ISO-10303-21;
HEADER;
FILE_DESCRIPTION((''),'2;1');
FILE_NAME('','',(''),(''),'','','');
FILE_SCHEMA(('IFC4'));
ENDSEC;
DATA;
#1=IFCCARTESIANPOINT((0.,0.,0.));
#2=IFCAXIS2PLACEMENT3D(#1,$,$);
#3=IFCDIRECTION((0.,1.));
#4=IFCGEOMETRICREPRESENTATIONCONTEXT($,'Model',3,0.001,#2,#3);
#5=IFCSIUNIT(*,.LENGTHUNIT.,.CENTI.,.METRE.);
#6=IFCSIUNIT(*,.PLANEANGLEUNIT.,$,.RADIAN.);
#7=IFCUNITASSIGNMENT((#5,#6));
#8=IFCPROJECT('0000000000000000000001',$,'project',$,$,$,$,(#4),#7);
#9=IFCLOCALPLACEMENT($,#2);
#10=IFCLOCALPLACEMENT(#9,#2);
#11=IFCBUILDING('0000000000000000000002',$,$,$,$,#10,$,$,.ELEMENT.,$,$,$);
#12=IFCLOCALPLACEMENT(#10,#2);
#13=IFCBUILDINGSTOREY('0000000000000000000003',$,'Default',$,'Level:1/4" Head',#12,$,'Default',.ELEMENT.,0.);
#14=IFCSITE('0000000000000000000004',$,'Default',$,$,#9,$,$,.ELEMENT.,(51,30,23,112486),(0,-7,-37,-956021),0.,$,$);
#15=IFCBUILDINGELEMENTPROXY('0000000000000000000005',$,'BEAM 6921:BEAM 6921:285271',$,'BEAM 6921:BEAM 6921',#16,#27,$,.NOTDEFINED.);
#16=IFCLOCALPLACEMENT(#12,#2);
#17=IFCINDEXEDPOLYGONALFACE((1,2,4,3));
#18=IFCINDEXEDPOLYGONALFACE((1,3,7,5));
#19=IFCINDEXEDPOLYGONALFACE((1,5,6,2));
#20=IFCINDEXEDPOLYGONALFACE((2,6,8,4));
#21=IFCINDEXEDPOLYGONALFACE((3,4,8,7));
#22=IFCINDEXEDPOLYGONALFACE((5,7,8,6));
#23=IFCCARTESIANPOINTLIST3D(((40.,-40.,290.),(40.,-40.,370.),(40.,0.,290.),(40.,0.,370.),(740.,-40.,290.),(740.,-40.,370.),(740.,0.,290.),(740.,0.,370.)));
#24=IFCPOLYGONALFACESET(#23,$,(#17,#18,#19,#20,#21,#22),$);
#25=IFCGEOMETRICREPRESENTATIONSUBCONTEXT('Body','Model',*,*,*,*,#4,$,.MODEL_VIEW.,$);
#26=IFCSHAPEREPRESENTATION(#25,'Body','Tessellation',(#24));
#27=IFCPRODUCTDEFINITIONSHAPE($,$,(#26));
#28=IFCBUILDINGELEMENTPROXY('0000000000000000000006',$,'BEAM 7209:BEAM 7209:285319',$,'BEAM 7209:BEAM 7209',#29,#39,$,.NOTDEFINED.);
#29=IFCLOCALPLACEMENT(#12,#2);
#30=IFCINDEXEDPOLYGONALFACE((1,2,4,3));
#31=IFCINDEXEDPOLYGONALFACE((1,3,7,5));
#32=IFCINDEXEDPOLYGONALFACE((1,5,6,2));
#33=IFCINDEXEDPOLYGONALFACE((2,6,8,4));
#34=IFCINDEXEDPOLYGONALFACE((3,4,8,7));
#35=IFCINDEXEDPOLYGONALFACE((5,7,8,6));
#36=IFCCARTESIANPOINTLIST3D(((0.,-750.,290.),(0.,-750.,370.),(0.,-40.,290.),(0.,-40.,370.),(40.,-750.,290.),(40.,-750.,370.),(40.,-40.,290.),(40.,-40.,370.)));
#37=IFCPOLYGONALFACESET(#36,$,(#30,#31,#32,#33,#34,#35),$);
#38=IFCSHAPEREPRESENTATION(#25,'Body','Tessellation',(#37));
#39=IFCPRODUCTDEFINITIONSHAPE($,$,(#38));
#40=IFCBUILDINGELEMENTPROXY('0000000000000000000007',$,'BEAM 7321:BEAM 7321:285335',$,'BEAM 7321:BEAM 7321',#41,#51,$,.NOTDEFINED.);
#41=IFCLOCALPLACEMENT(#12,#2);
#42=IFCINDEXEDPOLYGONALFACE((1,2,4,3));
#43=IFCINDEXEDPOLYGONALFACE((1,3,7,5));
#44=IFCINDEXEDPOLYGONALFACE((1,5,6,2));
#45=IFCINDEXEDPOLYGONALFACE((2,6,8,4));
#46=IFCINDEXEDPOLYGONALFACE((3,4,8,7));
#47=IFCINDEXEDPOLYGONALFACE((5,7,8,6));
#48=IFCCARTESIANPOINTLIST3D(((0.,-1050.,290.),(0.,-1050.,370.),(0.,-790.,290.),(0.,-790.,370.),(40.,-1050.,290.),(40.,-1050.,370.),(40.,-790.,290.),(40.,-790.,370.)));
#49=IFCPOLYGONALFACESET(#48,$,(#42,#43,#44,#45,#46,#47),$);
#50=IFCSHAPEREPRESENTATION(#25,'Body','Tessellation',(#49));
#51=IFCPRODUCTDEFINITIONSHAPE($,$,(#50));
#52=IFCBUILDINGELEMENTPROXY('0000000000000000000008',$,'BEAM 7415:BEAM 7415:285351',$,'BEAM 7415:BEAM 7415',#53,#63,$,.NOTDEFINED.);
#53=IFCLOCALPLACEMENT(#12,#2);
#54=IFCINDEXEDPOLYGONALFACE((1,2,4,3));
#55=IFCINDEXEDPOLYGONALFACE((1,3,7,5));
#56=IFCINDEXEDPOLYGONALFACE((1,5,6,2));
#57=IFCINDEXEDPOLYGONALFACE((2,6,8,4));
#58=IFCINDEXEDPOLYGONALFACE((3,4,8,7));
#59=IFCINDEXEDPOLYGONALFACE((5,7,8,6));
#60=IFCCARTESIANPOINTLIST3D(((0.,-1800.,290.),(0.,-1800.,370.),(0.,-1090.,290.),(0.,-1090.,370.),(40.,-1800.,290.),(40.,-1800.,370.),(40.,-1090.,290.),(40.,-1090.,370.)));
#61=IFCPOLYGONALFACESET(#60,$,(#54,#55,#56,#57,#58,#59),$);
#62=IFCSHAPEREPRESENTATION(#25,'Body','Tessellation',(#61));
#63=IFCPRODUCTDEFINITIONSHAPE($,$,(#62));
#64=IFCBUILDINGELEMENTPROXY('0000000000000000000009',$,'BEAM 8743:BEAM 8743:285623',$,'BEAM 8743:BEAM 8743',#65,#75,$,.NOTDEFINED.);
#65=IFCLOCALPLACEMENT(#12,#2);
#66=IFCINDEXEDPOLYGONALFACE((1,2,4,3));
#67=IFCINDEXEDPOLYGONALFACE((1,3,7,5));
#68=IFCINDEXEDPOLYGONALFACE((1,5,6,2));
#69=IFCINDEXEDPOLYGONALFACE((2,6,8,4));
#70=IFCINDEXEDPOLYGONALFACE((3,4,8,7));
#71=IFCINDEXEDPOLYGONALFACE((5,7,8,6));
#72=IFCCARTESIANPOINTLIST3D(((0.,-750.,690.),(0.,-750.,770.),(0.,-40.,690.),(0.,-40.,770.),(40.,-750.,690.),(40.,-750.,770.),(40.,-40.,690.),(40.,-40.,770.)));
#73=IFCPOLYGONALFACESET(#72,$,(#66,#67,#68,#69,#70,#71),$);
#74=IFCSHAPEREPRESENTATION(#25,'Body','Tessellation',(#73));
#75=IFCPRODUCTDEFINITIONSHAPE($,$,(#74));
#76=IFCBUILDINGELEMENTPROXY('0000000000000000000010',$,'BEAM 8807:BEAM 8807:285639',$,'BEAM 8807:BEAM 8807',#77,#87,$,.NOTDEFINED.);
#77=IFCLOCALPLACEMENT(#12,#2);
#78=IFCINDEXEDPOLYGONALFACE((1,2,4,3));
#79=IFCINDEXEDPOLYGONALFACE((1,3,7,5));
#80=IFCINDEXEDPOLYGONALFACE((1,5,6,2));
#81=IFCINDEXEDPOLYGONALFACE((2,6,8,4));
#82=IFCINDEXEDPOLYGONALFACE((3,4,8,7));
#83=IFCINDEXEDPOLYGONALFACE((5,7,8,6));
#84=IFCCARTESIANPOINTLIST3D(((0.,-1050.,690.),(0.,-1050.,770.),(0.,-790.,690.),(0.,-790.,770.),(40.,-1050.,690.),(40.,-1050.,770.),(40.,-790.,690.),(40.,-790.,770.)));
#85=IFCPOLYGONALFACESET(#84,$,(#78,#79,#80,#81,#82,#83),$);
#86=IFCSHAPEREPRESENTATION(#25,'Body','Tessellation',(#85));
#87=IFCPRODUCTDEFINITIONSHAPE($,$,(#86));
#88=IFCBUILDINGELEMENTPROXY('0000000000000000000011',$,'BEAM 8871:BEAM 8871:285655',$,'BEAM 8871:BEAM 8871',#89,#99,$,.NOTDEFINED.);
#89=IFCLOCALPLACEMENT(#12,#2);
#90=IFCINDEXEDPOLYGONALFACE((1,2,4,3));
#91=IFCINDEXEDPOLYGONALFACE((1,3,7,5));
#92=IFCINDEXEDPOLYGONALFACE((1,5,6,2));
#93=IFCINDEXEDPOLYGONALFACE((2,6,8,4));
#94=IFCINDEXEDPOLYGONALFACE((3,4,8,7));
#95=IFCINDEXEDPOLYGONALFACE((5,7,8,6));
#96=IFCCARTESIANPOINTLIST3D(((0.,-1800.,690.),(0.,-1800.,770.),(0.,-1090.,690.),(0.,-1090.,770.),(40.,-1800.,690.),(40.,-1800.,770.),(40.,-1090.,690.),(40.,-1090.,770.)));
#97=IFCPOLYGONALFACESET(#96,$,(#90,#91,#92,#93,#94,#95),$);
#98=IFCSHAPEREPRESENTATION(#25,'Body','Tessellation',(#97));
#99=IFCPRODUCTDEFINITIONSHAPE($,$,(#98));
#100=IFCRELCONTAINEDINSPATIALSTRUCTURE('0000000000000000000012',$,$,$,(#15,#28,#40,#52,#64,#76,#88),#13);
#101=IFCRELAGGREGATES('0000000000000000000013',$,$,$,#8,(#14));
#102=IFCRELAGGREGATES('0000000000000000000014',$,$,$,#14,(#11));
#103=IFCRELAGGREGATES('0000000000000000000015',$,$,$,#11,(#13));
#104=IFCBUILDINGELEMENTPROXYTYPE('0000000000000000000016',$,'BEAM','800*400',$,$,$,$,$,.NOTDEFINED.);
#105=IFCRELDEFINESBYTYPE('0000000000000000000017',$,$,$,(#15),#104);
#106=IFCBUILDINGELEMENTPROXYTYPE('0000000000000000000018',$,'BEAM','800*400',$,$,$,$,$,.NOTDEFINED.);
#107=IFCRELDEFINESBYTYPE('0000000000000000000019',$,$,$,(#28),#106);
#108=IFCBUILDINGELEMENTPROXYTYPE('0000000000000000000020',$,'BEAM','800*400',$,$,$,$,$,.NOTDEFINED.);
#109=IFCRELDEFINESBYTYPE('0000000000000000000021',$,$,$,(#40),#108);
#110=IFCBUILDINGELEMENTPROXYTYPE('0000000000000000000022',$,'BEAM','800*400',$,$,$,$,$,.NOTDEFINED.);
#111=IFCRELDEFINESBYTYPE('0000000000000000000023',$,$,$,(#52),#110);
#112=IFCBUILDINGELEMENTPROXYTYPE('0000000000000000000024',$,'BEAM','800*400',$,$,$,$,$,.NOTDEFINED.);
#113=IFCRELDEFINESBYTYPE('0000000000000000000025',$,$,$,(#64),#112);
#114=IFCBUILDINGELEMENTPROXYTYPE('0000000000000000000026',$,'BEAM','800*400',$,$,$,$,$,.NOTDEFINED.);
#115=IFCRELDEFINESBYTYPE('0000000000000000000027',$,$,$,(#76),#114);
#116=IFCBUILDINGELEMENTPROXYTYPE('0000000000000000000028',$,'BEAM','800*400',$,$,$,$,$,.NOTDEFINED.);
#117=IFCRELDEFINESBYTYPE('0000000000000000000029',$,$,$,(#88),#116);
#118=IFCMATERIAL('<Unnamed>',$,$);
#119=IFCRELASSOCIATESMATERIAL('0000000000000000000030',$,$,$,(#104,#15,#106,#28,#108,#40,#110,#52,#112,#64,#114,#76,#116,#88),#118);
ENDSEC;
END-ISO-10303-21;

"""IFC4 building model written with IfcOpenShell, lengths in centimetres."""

from ifc_helpers import new_model, si_unit, direction, frame, frame_2d, origin, origin_2d_with_axis, place, context, subcontext, project, spatial, rectangle, extrude, source, transform, mapped, material, type_object, type_shapes, element, save


model = new_model("IFC4")

# Units and contexts
model_context = context("Model", 3, precision=0.001, world=origin(), true_north=direction((0.0, 1.0)))
body_context = subcontext(model_context, "Body", "Model", "MODEL_VIEW")
ifc_project = project(units=[si_unit("LENGTHUNIT", "METRE", prefix="CENTI"), si_unit("PLANEANGLEUNIT", "RADIAN")], contexts=[model_context])

# Site, building, storey
site_placement = place(None, origin())
site = spatial("IfcSite", under=ifc_project, at=site_placement, Name="Default", CompositionType="ELEMENT", RefLatitude=(51, 30, 23, 112486), RefLongitude=(0, -7, -37, -956021), RefElevation=0.0)
building_placement = place(site_placement, origin())
building = spatial("IfcBuilding", under=site, at=building_placement, CompositionType="ELEMENT")
storey_placement = place(building_placement, origin())
storey = spatial("IfcBuildingStorey", under=building, at=storey_placement, Name="Default", ObjectType="Level:1/4\" Head", LongName="Default", CompositionType="ELEMENT", Elevation=0.0)

# Shared definitions
ifc_material_1 = material(Name="<Unnamed>")

# Building element proxies
building_element_proxy_type_1 = type_object("IfcBuildingElementProxyType", Name="BEAM", Description="800*400", PredefinedType="NOTDEFINED", material=ifc_material_1)
shared_shape_1 = source(origin(), body_context, "Body", "SweptSolid", [
    extrude(rectangle(XDim=40.0, YDim=700.0, at=origin_2d_with_axis()), frame((350.0, 20.0, 0.0), z_axis=(0.0, 0.0, 1.0), x_axis=(0.0, 1.0, 0.0)), (0.0, 0.0, 1.0), 80.0),
])
type_shapes(building_element_proxy_type_1, [shared_shape_1])
proxy_1_placement = place(storey_placement, frame((40.0, -40.0, 290.0)))
element("IfcBuildingElementProxy", 1, at=proxy_1_placement, inside=storey, type_object=building_element_proxy_type_1, material=ifc_material_1, Name="BEAM 6921:BEAM 6921:285271", ObjectType="BEAM 6921:BEAM 6921", PredefinedType="NOTDEFINED", context=body_context, shape_type="MappedRepresentation", body=[
    mapped(shared_shape_1, transform((0.0, 0.0, 0.0), scale=1.0)),
])
building_element_proxy_type_2 = type_object("IfcBuildingElementProxyType", Name="BEAM", Description="800*400", PredefinedType="NOTDEFINED", material=ifc_material_1)
shared_shape_2 = source(origin(), body_context, "Body", "SweptSolid", [
    extrude(rectangle(XDim=40.0, YDim=710.0, at=origin_2d_with_axis()), frame((20.0, 355.0, 0.0)), (0.0, 0.0, 1.0), 80.0),
])
type_shapes(building_element_proxy_type_2, [shared_shape_2])
proxy_2_placement = place(storey_placement, frame((0.0, -750.0, 290.0)))
element("IfcBuildingElementProxy", 2, at=proxy_2_placement, inside=storey, type_object=building_element_proxy_type_2, material=ifc_material_1, Name="BEAM 7209:BEAM 7209:285319", ObjectType="BEAM 7209:BEAM 7209", PredefinedType="NOTDEFINED", context=body_context, shape_type="MappedRepresentation", body=[
    mapped(shared_shape_2, transform((0.0, 0.0, 0.0), scale=1.0)),
])
building_element_proxy_type_3 = type_object("IfcBuildingElementProxyType", Name="BEAM", Description="800*400", PredefinedType="NOTDEFINED", material=ifc_material_1)
shared_shape_3 = source(origin(), body_context, "Body", "SweptSolid", [
    extrude(rectangle(XDim=40.0, YDim=260.0, at=frame_2d((0.0, 0.0), x_axis=(1.0, 0.0))), frame((20.0, 130.0, 0.0)), (0.0, 0.0, 1.0), 80.0),
])
type_shapes(building_element_proxy_type_3, [shared_shape_3])
proxy_3_placement = place(storey_placement, frame((0.0, -1050.0, 290.0)))
element("IfcBuildingElementProxy", 3, at=proxy_3_placement, inside=storey, type_object=building_element_proxy_type_3, material=ifc_material_1, Name="BEAM 7321:BEAM 7321:285335", ObjectType="BEAM 7321:BEAM 7321", PredefinedType="NOTDEFINED", context=body_context, shape_type="MappedRepresentation", body=[
    mapped(shared_shape_3, transform((0.0, 0.0, 0.0), scale=1.0)),
])
building_element_proxy_type_4 = type_object("IfcBuildingElementProxyType", Name="BEAM", Description="800*400", PredefinedType="NOTDEFINED", material=ifc_material_1)
shared_shape_4 = source(origin(), body_context, "Body", "SweptSolid", [
    extrude(rectangle(XDim=40.0, YDim=710.0, at=origin_2d_with_axis()), frame((20.0, 355.0, 0.0)), (0.0, 0.0, 1.0), 80.0),
])
type_shapes(building_element_proxy_type_4, [shared_shape_4])
proxy_4_placement = place(storey_placement, frame((0.0, -1800.0, 290.0)))
element("IfcBuildingElementProxy", 4, at=proxy_4_placement, inside=storey, type_object=building_element_proxy_type_4, material=ifc_material_1, Name="BEAM 7415:BEAM 7415:285351", ObjectType="BEAM 7415:BEAM 7415", PredefinedType="NOTDEFINED", context=body_context, shape_type="MappedRepresentation", body=[
    mapped(shared_shape_4, transform((0.0, 0.0, 0.0), scale=1.0)),
])
building_element_proxy_type_5 = type_object("IfcBuildingElementProxyType", Name="BEAM", Description="800*400", PredefinedType="NOTDEFINED", material=ifc_material_1)
shared_shape_5 = source(origin(), body_context, "Body", "SweptSolid", [
    extrude(rectangle(XDim=40.0, YDim=710.0, at=origin_2d_with_axis()), frame((20.0, 355.0, 0.0)), (0.0, 0.0, 1.0), 80.0),
])
type_shapes(building_element_proxy_type_5, [shared_shape_5])
proxy_5_placement = place(storey_placement, frame((0.0, -750.0, 690.0)))
element("IfcBuildingElementProxy", 5, at=proxy_5_placement, inside=storey, type_object=building_element_proxy_type_5, material=ifc_material_1, Name="BEAM 8743:BEAM 8743:285623", ObjectType="BEAM 8743:BEAM 8743", PredefinedType="NOTDEFINED", context=body_context, shape_type="MappedRepresentation", body=[
    mapped(shared_shape_5, transform((0.0, 0.0, 0.0), scale=1.0)),
])
building_element_proxy_type_6 = type_object("IfcBuildingElementProxyType", Name="BEAM", Description="800*400", PredefinedType="NOTDEFINED", material=ifc_material_1)
shared_shape_6 = source(origin(), body_context, "Body", "SweptSolid", [
    extrude(rectangle(XDim=40.0, YDim=260.0, at=frame_2d((0.0, 0.0), x_axis=(1.0, 0.0))), frame((20.0, 130.0, 0.0)), (0.0, 0.0, 1.0), 80.0),
])
type_shapes(building_element_proxy_type_6, [shared_shape_6])
proxy_6_placement = place(storey_placement, frame((0.0, -1050.0, 690.0)))
element("IfcBuildingElementProxy", 6, at=proxy_6_placement, inside=storey, type_object=building_element_proxy_type_6, material=ifc_material_1, Name="BEAM 8807:BEAM 8807:285639", ObjectType="BEAM 8807:BEAM 8807", PredefinedType="NOTDEFINED", context=body_context, shape_type="MappedRepresentation", body=[
    mapped(shared_shape_6, transform((0.0, 0.0, 0.0), scale=1.0)),
])
building_element_proxy_type_7 = type_object("IfcBuildingElementProxyType", Name="BEAM", Description="800*400", PredefinedType="NOTDEFINED", material=ifc_material_1)
shared_shape_7 = source(origin(), body_context, "Body", "SweptSolid", [
    extrude(rectangle(XDim=40.0, YDim=710.0, at=origin_2d_with_axis()), frame((20.0, 355.0, 0.0)), (0.0, 0.0, 1.0), 80.0),
])
type_shapes(building_element_proxy_type_7, [shared_shape_7])
proxy_7_placement = place(storey_placement, frame((0.0, -1800.0, 690.0)))
element("IfcBuildingElementProxy", 7, at=proxy_7_placement, inside=storey, type_object=building_element_proxy_type_7, material=ifc_material_1, Name="BEAM 8871:BEAM 8871:285655", ObjectType="BEAM 8871:BEAM 8871", PredefinedType="NOTDEFINED", context=body_context, shape_type="MappedRepresentation", body=[
    mapped(shared_shape_7, transform((0.0, 0.0, 0.0), scale=1.0)),
])

save(model, "model.ifc")
